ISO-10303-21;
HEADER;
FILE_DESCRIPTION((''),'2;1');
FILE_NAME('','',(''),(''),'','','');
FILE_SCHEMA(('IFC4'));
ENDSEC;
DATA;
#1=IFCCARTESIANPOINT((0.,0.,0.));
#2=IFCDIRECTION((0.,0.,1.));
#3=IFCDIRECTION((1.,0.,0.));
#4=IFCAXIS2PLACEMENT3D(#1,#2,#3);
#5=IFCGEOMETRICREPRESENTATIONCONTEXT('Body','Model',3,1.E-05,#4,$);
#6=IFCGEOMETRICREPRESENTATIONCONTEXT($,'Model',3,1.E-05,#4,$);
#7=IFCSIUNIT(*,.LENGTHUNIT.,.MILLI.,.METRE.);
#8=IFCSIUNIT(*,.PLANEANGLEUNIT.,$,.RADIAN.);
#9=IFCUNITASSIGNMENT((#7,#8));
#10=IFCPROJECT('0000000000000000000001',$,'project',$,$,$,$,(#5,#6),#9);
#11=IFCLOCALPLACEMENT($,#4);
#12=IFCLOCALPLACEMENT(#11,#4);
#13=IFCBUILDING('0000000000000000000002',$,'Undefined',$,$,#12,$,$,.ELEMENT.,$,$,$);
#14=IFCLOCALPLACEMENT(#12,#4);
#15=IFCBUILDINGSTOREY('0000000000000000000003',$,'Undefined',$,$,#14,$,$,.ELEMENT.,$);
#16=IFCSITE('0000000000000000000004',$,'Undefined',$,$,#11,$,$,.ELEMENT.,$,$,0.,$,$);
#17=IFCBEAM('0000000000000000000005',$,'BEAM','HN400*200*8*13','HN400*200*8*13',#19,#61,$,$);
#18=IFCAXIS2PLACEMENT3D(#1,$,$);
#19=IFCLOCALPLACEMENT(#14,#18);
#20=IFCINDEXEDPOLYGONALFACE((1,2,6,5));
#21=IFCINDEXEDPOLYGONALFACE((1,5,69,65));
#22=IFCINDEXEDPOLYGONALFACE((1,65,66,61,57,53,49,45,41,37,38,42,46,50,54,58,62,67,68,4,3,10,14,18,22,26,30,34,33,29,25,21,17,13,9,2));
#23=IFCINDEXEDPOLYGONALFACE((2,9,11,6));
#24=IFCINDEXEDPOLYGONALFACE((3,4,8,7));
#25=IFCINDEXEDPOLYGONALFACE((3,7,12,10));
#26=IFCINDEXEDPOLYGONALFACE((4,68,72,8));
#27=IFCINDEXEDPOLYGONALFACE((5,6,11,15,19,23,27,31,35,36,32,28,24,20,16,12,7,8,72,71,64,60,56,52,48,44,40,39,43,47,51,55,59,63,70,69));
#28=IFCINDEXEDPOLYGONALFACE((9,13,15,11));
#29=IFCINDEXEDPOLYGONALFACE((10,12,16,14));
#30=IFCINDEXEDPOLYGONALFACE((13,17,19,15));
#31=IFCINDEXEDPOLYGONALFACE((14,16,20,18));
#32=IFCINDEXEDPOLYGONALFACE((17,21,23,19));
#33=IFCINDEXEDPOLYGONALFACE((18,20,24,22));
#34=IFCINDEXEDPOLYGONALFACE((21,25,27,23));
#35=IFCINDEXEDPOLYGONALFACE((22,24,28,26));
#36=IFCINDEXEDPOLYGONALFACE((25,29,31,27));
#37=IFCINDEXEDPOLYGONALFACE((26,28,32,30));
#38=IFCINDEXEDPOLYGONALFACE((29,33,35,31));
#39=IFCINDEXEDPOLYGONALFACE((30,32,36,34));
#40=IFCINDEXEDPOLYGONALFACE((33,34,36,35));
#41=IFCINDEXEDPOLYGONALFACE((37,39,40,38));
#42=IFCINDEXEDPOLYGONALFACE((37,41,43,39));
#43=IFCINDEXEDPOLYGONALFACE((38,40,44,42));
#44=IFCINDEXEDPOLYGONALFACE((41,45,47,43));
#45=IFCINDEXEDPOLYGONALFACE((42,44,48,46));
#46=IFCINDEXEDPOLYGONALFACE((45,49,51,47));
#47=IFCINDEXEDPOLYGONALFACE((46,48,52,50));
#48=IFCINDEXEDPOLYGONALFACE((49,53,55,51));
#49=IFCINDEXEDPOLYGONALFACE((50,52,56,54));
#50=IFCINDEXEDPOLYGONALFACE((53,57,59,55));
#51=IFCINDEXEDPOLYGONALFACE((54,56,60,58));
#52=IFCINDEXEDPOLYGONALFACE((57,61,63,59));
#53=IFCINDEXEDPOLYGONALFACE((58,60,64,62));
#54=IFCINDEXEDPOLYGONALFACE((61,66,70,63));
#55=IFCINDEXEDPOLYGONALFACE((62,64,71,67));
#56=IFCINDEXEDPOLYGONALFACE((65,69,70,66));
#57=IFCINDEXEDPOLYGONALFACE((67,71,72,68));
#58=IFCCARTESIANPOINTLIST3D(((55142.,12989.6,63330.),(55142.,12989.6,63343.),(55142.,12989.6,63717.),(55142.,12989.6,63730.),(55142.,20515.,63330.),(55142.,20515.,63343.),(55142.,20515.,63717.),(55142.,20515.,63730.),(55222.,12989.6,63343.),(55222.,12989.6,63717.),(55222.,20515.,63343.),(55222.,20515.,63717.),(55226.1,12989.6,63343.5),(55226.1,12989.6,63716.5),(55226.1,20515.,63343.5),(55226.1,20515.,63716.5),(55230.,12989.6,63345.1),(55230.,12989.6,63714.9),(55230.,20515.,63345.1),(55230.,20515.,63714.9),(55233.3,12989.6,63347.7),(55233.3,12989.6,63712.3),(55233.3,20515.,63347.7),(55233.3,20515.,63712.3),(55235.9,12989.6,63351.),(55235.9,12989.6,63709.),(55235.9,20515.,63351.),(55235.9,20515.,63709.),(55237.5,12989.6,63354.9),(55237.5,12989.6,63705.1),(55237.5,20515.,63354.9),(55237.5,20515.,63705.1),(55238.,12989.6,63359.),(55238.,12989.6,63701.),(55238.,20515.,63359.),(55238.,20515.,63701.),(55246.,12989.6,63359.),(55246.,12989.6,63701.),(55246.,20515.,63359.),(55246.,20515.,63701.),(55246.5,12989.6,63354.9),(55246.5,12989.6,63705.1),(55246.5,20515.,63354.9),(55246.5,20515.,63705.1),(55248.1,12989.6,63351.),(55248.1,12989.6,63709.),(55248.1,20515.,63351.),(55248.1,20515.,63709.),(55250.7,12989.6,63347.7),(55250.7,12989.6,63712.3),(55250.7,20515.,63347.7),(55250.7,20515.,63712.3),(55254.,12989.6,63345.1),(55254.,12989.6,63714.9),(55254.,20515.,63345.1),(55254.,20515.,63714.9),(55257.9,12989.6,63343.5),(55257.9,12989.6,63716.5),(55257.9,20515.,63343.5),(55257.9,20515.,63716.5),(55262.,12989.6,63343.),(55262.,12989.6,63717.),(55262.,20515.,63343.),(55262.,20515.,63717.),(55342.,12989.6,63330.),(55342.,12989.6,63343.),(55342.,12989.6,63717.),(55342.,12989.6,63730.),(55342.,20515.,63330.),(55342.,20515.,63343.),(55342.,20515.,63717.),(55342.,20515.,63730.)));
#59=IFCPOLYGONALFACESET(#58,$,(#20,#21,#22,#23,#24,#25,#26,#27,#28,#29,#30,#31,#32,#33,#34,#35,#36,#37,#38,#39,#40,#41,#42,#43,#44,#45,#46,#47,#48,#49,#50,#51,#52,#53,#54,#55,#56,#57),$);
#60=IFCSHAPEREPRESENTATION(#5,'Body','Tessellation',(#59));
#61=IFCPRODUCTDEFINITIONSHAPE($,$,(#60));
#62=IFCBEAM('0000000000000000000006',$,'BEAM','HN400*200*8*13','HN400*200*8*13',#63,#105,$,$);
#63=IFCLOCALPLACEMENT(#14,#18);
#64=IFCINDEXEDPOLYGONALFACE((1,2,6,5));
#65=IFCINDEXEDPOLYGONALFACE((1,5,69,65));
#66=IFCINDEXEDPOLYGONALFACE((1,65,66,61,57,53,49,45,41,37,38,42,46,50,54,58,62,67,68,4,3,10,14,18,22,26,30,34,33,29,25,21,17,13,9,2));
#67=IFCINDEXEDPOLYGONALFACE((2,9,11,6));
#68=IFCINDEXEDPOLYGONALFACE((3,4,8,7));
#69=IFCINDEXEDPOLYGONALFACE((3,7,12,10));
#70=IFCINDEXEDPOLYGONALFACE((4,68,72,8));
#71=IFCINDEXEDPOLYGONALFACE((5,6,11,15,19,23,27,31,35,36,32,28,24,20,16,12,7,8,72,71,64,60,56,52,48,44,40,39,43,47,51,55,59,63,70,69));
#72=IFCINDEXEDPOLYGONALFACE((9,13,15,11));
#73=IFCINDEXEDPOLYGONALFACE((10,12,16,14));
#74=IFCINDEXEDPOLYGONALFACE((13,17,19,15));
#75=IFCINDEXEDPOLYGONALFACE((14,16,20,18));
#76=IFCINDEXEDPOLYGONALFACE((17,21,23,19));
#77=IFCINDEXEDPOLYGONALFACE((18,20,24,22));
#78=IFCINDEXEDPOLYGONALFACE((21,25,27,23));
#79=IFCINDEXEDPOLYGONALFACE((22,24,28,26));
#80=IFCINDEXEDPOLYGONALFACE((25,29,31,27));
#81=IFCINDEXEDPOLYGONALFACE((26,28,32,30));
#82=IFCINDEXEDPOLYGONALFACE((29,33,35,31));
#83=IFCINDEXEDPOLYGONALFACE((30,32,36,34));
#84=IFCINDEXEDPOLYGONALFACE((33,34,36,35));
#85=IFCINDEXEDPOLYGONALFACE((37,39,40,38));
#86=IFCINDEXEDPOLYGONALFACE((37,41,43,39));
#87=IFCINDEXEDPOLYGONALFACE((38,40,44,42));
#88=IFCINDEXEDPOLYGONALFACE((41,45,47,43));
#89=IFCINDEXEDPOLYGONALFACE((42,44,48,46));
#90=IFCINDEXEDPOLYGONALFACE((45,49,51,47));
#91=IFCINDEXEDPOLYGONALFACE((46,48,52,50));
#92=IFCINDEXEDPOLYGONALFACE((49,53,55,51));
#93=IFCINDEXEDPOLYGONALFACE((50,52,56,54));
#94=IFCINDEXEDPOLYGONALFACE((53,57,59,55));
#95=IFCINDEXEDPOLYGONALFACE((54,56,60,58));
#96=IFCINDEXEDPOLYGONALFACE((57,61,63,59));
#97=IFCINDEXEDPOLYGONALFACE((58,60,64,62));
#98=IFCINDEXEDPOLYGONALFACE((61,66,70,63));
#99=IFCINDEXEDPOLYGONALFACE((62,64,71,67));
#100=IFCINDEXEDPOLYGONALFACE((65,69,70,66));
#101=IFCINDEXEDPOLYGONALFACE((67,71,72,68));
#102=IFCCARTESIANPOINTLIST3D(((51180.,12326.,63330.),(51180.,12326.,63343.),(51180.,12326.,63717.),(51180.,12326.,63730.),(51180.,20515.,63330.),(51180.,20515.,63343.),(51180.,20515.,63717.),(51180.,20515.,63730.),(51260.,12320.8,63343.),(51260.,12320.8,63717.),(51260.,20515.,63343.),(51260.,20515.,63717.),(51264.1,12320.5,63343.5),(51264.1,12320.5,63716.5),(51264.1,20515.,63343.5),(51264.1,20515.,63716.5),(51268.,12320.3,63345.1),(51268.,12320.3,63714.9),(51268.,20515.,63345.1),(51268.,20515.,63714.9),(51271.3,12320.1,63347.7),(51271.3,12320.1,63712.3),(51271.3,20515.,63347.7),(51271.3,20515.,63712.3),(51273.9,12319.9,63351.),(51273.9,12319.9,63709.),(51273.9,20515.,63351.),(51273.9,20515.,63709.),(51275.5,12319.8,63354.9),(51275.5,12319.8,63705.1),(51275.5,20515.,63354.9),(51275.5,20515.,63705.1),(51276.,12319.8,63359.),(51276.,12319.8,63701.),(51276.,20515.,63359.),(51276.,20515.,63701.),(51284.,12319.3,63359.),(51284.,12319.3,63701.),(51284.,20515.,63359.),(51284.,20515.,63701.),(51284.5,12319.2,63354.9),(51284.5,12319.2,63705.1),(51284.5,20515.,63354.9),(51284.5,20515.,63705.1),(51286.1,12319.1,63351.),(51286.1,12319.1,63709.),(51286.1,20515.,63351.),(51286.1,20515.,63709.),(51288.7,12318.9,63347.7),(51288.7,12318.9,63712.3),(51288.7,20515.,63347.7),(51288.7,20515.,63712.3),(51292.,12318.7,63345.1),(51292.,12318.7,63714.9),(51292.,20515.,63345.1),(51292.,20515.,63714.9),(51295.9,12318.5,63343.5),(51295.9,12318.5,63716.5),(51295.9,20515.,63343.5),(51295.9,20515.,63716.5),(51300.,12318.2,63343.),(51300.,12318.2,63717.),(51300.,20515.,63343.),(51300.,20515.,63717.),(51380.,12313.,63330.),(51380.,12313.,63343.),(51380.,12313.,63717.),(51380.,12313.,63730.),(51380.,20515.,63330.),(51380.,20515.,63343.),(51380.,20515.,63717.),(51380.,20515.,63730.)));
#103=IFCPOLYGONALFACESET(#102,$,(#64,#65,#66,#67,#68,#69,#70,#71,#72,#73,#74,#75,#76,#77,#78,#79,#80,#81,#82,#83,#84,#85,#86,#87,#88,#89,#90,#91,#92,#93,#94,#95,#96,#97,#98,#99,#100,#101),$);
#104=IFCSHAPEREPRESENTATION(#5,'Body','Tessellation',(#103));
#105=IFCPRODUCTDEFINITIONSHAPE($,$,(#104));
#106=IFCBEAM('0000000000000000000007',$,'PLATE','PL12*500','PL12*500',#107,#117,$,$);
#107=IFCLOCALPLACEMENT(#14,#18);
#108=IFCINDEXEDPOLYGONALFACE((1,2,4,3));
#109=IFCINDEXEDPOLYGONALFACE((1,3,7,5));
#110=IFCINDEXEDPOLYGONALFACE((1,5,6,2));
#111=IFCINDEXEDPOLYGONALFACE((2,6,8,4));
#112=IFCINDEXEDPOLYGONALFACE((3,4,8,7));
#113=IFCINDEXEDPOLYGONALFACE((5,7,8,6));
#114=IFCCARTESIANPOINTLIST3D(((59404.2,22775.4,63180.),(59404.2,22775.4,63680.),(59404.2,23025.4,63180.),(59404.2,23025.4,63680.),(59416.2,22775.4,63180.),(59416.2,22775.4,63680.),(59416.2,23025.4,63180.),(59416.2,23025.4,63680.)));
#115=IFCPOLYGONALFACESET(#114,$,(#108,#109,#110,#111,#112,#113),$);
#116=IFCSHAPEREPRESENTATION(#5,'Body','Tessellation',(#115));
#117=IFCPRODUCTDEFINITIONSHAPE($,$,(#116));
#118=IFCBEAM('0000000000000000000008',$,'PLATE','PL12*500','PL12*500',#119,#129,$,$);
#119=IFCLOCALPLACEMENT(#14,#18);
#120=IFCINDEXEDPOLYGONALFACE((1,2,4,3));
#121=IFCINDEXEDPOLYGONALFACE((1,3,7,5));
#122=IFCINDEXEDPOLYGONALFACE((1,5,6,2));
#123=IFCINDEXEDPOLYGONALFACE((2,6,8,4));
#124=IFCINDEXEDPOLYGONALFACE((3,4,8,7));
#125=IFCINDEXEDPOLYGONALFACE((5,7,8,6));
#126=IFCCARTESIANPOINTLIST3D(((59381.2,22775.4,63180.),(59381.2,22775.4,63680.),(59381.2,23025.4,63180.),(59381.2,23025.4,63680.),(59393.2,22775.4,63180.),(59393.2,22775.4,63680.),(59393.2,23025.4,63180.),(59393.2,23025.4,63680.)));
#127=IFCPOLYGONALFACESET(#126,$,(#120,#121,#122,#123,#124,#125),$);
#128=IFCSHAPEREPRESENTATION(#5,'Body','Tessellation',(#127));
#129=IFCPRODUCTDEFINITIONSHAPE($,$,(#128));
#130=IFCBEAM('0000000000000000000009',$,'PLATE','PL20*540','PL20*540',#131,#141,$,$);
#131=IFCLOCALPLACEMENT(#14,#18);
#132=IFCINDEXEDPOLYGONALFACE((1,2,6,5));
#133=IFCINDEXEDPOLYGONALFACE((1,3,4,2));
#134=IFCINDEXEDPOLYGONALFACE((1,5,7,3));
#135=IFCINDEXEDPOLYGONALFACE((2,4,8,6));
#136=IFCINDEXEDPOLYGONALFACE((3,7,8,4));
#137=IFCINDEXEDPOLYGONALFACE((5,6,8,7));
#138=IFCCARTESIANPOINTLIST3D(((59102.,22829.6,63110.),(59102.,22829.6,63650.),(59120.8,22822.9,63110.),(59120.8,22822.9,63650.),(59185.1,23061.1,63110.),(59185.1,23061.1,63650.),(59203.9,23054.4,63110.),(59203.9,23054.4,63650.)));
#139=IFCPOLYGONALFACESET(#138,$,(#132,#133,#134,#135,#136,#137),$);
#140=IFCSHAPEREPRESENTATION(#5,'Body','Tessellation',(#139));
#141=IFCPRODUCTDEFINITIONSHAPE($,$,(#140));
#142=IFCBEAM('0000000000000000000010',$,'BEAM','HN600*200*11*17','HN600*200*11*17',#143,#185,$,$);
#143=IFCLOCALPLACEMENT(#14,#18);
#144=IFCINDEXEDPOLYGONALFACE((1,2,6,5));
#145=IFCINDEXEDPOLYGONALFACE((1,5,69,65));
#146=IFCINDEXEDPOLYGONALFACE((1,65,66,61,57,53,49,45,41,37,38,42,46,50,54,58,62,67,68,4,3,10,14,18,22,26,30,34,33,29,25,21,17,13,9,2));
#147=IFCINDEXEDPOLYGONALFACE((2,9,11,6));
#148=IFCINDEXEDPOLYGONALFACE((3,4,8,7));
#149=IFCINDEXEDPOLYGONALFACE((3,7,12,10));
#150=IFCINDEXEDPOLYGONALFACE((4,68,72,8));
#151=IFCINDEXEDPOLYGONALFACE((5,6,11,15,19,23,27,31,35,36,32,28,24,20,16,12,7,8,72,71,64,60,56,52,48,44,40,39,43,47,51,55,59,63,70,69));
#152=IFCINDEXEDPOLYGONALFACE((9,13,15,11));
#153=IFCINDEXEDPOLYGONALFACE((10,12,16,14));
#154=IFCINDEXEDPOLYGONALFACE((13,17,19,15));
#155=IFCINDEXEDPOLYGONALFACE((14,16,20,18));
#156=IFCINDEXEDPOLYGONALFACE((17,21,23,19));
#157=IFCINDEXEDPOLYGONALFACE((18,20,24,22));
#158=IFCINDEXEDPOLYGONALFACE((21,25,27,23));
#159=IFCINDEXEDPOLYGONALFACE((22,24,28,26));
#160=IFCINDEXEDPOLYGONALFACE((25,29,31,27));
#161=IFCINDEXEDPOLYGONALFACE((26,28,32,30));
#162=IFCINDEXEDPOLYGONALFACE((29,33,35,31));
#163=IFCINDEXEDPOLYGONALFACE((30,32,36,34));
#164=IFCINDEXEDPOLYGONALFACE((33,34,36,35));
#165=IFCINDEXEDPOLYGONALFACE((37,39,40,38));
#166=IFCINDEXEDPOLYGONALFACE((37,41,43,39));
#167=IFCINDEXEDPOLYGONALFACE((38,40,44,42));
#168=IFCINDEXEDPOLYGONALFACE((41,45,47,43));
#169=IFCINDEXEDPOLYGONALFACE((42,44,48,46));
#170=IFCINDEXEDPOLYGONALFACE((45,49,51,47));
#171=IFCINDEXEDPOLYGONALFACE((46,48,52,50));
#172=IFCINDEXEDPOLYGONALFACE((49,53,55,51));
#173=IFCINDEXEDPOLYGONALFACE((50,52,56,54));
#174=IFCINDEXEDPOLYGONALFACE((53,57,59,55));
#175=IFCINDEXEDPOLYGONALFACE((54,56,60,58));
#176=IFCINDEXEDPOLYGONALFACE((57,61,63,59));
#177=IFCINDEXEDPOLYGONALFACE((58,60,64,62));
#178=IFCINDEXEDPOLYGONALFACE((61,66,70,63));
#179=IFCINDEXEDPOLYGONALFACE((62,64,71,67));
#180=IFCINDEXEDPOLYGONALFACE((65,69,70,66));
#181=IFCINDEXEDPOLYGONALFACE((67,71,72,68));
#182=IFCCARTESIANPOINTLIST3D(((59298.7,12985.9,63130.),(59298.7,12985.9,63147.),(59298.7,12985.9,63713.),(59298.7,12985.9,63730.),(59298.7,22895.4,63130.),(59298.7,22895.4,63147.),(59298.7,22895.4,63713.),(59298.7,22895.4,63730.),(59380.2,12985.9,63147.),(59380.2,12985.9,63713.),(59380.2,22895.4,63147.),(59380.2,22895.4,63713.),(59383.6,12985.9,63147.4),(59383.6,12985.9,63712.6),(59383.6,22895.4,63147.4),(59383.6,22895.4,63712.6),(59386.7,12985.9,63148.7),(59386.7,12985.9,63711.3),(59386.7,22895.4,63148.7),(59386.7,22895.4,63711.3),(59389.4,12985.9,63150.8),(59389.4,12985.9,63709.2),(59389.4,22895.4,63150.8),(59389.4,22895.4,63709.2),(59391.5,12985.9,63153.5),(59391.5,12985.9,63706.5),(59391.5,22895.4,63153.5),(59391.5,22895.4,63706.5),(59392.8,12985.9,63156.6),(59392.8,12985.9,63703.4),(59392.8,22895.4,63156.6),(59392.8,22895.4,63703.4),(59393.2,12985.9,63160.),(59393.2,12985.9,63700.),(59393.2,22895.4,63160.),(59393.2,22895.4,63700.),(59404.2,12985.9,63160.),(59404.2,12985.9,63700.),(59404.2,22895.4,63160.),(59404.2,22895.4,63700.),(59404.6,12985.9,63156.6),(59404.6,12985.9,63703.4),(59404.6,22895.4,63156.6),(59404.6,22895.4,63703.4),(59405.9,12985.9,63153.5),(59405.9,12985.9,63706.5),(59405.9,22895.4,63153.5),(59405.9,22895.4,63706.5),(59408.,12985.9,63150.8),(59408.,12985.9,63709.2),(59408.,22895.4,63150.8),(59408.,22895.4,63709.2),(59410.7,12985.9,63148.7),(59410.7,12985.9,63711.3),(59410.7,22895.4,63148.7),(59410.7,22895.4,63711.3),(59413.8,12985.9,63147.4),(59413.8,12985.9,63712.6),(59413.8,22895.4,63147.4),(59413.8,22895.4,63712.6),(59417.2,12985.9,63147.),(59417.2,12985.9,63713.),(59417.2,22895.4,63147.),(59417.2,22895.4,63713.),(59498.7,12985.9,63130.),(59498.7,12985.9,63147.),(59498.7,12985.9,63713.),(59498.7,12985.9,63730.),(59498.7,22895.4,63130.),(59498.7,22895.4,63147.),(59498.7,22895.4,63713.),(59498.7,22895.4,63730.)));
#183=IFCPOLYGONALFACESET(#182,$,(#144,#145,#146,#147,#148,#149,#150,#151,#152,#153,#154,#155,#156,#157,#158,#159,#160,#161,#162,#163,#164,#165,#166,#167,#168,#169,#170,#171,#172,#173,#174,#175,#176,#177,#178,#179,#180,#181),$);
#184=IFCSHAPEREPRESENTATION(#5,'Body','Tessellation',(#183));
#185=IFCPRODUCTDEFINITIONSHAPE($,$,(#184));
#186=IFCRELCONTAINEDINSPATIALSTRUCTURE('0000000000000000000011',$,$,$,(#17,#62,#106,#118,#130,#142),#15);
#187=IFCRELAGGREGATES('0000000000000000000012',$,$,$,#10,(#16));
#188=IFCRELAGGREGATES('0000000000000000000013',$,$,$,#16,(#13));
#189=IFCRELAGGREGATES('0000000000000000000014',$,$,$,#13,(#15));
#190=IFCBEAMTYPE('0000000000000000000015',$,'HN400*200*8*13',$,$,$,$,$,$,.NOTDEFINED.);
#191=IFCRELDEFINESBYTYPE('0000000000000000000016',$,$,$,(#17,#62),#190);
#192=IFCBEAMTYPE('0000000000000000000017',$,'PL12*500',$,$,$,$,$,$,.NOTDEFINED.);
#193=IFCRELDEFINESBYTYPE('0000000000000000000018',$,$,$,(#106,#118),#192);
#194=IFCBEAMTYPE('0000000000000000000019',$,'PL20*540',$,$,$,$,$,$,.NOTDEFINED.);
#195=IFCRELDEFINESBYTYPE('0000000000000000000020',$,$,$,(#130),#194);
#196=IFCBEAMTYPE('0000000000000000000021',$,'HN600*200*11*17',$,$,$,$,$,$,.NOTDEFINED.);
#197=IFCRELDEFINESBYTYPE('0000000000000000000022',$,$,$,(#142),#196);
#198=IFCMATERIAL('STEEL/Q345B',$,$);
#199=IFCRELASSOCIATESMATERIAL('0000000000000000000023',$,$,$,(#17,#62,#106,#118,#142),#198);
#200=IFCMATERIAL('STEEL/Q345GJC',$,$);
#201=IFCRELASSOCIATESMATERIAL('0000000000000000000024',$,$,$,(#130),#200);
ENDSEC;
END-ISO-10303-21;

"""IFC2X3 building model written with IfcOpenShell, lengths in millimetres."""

from ifc_helpers import new_model, si_unit, frame, origin_with_axes, origin_2d_with_axis, place, context, project, spatial, rectangle, i_section, extrude, clip, halfspace, material, type_object, element, save


model = new_model("IFC2X3")

# Units and contexts
model_context_1 = context("Model", 3, precision=1e-05, world=origin_with_axes(), identifier="Body")
model_context_2 = context("Model", 3, precision=1e-05, world=origin_with_axes())
ifc_project = project(units=[si_unit("LENGTHUNIT", "METRE", prefix="MILLI"), si_unit("PLANEANGLEUNIT", "RADIAN")], contexts=[model_context_1, model_context_2])

# Site, building, storey
site_placement = place(None, origin_with_axes())
site = spatial("IfcSite", under=ifc_project, at=site_placement, Name="Undefined", CompositionType="ELEMENT", RefElevation=0.0)
building_placement = place(site_placement, origin_with_axes())
building = spatial("IfcBuilding", under=site, at=building_placement, Name="Undefined", CompositionType="ELEMENT")
storey_placement = place(building_placement, origin_with_axes())
storey = spatial("IfcBuildingStorey", under=building, at=storey_placement, Name="Undefined", CompositionType="ELEMENT")

# Beams
ifc_material_1 = material(Name="STEEL/Q345B")
beam_type_1 = type_object("IfcBeamType", Name="HN400*200*8*13", PredefinedType="NOTDEFINED")
beam_1_placement = place(storey_placement, frame((55242.0, 20680.0, 63530.0), z_axis=(0.0, 0.0, 1.0), x_axis=(0.0, -1.0, 0.0)))
element("IfcBeam", 1, at=beam_1_placement, inside=storey, type_object=beam_type_1, material=ifc_material_1, Name="BEAM", Description="HN400*200*8*13", ObjectType="HN400*200*8*13", context=model_context_1, shape_type="SweptSolid", body=[
    extrude(i_section(OverallWidth=200.0, OverallDepth=400.0, WebThickness=8.0, FlangeThickness=13.0, FilletRadius=16.0, at=origin_2d_with_axis()), frame((7690.4, 0.0, 0.0), z_axis=(-1.0, 0.0, 0.0), x_axis=(0.0, -1.0, 0.0)), (0.0, 0.0, 1.0), 7525.4),
])
beam_2_placement = place(storey_placement, frame((51280.0, 20680.0, 63530.0), z_axis=(0.0, 0.0, 1.0), x_axis=(0.0, -1.0, 0.0)))
element("IfcBeam", 2, at=beam_2_placement, inside=storey, type_object=beam_type_1, material=ifc_material_1, Name="BEAM", Description="HN400*200*8*13", ObjectType="HN400*200*8*13", context=model_context_1, shape_type="Clipping", body=[
    clip(clip(extrude(i_section(OverallWidth=200.0, OverallDepth=400.0, WebThickness=8.0, FlangeThickness=13.0, FilletRadius=16.0, at=origin_2d_with_axis()), frame((8367.1, 0.0, 0.0), z_axis=(-1.0, 0.0, 0.0), x_axis=(0.0, -1.0, 0.0)), (0.0, 0.0, 1.0), 8202.1), halfspace(frame((165.0, -58.0, 200.0), z_axis=(1.0, 0.0, 0.0), x_axis=(0.0, 0.0, 1.0)), True)), halfspace(frame((8361.3, 13.2, 300.0), z_axis=(0.997873, -0.065183, 0.0), x_axis=(0.065184, 0.997873, 0.0)), False)),
])
beam_type_2 = type_object("IfcBeamType", Name="PL12*500", PredefinedType="NOTDEFINED")
for number, where, z_axis, x_axis, name in (
    (3, (59410.2, 23025.4, 63430.0), (0.0, 0.0, 1.0), (0.0, -1.0, 0.0), "PLATE"),
    (4, (59387.2, 23025.4, 63430.0), (0.0, 0.0, 1.0), (0.0, -1.0, 0.0), "PLATE"),
):
    element("IfcBeam", number, at=place(storey_placement, frame(where, z_axis=z_axis, x_axis=x_axis)), inside=storey, type_object=beam_type_2, material=ifc_material_1, Name=name, Description="PL12*500", ObjectType="PL12*500", context=model_context_1, shape_type="SweptSolid", body=[
        extrude(rectangle(XDim=12.0, YDim=500.0, at=origin_2d_with_axis()), frame((250.0, 0.0, 0.0), z_axis=(-1.0, 0.0, 0.0), x_axis=(0.0, -1.0, 0.0)), (0.0, 0.0, 1.0), 250.0),
    ])
ifc_material_2 = material(Name="STEEL/Q345GJC")
beam_type_3 = type_object("IfcBeamType", Name="PL20*540", PredefinedType="NOTDEFINED")
beam_3_placement = place(storey_placement, frame((59194.5, 23057.8, 63380.0), z_axis=(0.0, 0.0, 1.0), x_axis=(-0.337816, -0.941212, 0.0)))
element("IfcBeam", 5, at=beam_3_placement, inside=storey, type_object=beam_type_3, material=ifc_material_2, Name="PLATE", Description="PL20*540", ObjectType="PL20*540", context=model_context_1, shape_type="SweptSolid", body=[
    extrude(rectangle(XDim=20.0, YDim=540.0, at=origin_2d_with_axis()), frame((246.0, 0.0, 0.0), z_axis=(-1.0, 0.0, 0.0), x_axis=(0.0, -1.0, 0.0)), (0.0, 0.0, 1.0), 246.0),
])
beam_type_4 = type_object("IfcBeamType", Name="HN600*200*11*17", PredefinedType="NOTDEFINED")
beam_4_placement = place(storey_placement, frame((59398.7, 23680.0, 63430.0), z_axis=(0.0, 0.0, 1.0), x_axis=(0.0, -1.0, 0.0)))
element("IfcBeam", 6, at=beam_4_placement, inside=storey, type_object=beam_type_4, material=ifc_material_1, Name="BEAM", Description="HN600*200*11*17", ObjectType="HN600*200*11*17", context=model_context_1, shape_type="SweptSolid", body=[
    extrude(i_section(OverallWidth=200.0, OverallDepth=600.0, WebThickness=11.0, FlangeThickness=17.0, FilletRadius=13.0, at=origin_2d_with_axis()), frame((10694.1, 0.0, 0.0), z_axis=(-1.0, 0.0, 0.0), x_axis=(0.0, -1.0, 0.0)), (0.0, 0.0, 1.0), 9909.5),
])

save(model, "model.ifc")
